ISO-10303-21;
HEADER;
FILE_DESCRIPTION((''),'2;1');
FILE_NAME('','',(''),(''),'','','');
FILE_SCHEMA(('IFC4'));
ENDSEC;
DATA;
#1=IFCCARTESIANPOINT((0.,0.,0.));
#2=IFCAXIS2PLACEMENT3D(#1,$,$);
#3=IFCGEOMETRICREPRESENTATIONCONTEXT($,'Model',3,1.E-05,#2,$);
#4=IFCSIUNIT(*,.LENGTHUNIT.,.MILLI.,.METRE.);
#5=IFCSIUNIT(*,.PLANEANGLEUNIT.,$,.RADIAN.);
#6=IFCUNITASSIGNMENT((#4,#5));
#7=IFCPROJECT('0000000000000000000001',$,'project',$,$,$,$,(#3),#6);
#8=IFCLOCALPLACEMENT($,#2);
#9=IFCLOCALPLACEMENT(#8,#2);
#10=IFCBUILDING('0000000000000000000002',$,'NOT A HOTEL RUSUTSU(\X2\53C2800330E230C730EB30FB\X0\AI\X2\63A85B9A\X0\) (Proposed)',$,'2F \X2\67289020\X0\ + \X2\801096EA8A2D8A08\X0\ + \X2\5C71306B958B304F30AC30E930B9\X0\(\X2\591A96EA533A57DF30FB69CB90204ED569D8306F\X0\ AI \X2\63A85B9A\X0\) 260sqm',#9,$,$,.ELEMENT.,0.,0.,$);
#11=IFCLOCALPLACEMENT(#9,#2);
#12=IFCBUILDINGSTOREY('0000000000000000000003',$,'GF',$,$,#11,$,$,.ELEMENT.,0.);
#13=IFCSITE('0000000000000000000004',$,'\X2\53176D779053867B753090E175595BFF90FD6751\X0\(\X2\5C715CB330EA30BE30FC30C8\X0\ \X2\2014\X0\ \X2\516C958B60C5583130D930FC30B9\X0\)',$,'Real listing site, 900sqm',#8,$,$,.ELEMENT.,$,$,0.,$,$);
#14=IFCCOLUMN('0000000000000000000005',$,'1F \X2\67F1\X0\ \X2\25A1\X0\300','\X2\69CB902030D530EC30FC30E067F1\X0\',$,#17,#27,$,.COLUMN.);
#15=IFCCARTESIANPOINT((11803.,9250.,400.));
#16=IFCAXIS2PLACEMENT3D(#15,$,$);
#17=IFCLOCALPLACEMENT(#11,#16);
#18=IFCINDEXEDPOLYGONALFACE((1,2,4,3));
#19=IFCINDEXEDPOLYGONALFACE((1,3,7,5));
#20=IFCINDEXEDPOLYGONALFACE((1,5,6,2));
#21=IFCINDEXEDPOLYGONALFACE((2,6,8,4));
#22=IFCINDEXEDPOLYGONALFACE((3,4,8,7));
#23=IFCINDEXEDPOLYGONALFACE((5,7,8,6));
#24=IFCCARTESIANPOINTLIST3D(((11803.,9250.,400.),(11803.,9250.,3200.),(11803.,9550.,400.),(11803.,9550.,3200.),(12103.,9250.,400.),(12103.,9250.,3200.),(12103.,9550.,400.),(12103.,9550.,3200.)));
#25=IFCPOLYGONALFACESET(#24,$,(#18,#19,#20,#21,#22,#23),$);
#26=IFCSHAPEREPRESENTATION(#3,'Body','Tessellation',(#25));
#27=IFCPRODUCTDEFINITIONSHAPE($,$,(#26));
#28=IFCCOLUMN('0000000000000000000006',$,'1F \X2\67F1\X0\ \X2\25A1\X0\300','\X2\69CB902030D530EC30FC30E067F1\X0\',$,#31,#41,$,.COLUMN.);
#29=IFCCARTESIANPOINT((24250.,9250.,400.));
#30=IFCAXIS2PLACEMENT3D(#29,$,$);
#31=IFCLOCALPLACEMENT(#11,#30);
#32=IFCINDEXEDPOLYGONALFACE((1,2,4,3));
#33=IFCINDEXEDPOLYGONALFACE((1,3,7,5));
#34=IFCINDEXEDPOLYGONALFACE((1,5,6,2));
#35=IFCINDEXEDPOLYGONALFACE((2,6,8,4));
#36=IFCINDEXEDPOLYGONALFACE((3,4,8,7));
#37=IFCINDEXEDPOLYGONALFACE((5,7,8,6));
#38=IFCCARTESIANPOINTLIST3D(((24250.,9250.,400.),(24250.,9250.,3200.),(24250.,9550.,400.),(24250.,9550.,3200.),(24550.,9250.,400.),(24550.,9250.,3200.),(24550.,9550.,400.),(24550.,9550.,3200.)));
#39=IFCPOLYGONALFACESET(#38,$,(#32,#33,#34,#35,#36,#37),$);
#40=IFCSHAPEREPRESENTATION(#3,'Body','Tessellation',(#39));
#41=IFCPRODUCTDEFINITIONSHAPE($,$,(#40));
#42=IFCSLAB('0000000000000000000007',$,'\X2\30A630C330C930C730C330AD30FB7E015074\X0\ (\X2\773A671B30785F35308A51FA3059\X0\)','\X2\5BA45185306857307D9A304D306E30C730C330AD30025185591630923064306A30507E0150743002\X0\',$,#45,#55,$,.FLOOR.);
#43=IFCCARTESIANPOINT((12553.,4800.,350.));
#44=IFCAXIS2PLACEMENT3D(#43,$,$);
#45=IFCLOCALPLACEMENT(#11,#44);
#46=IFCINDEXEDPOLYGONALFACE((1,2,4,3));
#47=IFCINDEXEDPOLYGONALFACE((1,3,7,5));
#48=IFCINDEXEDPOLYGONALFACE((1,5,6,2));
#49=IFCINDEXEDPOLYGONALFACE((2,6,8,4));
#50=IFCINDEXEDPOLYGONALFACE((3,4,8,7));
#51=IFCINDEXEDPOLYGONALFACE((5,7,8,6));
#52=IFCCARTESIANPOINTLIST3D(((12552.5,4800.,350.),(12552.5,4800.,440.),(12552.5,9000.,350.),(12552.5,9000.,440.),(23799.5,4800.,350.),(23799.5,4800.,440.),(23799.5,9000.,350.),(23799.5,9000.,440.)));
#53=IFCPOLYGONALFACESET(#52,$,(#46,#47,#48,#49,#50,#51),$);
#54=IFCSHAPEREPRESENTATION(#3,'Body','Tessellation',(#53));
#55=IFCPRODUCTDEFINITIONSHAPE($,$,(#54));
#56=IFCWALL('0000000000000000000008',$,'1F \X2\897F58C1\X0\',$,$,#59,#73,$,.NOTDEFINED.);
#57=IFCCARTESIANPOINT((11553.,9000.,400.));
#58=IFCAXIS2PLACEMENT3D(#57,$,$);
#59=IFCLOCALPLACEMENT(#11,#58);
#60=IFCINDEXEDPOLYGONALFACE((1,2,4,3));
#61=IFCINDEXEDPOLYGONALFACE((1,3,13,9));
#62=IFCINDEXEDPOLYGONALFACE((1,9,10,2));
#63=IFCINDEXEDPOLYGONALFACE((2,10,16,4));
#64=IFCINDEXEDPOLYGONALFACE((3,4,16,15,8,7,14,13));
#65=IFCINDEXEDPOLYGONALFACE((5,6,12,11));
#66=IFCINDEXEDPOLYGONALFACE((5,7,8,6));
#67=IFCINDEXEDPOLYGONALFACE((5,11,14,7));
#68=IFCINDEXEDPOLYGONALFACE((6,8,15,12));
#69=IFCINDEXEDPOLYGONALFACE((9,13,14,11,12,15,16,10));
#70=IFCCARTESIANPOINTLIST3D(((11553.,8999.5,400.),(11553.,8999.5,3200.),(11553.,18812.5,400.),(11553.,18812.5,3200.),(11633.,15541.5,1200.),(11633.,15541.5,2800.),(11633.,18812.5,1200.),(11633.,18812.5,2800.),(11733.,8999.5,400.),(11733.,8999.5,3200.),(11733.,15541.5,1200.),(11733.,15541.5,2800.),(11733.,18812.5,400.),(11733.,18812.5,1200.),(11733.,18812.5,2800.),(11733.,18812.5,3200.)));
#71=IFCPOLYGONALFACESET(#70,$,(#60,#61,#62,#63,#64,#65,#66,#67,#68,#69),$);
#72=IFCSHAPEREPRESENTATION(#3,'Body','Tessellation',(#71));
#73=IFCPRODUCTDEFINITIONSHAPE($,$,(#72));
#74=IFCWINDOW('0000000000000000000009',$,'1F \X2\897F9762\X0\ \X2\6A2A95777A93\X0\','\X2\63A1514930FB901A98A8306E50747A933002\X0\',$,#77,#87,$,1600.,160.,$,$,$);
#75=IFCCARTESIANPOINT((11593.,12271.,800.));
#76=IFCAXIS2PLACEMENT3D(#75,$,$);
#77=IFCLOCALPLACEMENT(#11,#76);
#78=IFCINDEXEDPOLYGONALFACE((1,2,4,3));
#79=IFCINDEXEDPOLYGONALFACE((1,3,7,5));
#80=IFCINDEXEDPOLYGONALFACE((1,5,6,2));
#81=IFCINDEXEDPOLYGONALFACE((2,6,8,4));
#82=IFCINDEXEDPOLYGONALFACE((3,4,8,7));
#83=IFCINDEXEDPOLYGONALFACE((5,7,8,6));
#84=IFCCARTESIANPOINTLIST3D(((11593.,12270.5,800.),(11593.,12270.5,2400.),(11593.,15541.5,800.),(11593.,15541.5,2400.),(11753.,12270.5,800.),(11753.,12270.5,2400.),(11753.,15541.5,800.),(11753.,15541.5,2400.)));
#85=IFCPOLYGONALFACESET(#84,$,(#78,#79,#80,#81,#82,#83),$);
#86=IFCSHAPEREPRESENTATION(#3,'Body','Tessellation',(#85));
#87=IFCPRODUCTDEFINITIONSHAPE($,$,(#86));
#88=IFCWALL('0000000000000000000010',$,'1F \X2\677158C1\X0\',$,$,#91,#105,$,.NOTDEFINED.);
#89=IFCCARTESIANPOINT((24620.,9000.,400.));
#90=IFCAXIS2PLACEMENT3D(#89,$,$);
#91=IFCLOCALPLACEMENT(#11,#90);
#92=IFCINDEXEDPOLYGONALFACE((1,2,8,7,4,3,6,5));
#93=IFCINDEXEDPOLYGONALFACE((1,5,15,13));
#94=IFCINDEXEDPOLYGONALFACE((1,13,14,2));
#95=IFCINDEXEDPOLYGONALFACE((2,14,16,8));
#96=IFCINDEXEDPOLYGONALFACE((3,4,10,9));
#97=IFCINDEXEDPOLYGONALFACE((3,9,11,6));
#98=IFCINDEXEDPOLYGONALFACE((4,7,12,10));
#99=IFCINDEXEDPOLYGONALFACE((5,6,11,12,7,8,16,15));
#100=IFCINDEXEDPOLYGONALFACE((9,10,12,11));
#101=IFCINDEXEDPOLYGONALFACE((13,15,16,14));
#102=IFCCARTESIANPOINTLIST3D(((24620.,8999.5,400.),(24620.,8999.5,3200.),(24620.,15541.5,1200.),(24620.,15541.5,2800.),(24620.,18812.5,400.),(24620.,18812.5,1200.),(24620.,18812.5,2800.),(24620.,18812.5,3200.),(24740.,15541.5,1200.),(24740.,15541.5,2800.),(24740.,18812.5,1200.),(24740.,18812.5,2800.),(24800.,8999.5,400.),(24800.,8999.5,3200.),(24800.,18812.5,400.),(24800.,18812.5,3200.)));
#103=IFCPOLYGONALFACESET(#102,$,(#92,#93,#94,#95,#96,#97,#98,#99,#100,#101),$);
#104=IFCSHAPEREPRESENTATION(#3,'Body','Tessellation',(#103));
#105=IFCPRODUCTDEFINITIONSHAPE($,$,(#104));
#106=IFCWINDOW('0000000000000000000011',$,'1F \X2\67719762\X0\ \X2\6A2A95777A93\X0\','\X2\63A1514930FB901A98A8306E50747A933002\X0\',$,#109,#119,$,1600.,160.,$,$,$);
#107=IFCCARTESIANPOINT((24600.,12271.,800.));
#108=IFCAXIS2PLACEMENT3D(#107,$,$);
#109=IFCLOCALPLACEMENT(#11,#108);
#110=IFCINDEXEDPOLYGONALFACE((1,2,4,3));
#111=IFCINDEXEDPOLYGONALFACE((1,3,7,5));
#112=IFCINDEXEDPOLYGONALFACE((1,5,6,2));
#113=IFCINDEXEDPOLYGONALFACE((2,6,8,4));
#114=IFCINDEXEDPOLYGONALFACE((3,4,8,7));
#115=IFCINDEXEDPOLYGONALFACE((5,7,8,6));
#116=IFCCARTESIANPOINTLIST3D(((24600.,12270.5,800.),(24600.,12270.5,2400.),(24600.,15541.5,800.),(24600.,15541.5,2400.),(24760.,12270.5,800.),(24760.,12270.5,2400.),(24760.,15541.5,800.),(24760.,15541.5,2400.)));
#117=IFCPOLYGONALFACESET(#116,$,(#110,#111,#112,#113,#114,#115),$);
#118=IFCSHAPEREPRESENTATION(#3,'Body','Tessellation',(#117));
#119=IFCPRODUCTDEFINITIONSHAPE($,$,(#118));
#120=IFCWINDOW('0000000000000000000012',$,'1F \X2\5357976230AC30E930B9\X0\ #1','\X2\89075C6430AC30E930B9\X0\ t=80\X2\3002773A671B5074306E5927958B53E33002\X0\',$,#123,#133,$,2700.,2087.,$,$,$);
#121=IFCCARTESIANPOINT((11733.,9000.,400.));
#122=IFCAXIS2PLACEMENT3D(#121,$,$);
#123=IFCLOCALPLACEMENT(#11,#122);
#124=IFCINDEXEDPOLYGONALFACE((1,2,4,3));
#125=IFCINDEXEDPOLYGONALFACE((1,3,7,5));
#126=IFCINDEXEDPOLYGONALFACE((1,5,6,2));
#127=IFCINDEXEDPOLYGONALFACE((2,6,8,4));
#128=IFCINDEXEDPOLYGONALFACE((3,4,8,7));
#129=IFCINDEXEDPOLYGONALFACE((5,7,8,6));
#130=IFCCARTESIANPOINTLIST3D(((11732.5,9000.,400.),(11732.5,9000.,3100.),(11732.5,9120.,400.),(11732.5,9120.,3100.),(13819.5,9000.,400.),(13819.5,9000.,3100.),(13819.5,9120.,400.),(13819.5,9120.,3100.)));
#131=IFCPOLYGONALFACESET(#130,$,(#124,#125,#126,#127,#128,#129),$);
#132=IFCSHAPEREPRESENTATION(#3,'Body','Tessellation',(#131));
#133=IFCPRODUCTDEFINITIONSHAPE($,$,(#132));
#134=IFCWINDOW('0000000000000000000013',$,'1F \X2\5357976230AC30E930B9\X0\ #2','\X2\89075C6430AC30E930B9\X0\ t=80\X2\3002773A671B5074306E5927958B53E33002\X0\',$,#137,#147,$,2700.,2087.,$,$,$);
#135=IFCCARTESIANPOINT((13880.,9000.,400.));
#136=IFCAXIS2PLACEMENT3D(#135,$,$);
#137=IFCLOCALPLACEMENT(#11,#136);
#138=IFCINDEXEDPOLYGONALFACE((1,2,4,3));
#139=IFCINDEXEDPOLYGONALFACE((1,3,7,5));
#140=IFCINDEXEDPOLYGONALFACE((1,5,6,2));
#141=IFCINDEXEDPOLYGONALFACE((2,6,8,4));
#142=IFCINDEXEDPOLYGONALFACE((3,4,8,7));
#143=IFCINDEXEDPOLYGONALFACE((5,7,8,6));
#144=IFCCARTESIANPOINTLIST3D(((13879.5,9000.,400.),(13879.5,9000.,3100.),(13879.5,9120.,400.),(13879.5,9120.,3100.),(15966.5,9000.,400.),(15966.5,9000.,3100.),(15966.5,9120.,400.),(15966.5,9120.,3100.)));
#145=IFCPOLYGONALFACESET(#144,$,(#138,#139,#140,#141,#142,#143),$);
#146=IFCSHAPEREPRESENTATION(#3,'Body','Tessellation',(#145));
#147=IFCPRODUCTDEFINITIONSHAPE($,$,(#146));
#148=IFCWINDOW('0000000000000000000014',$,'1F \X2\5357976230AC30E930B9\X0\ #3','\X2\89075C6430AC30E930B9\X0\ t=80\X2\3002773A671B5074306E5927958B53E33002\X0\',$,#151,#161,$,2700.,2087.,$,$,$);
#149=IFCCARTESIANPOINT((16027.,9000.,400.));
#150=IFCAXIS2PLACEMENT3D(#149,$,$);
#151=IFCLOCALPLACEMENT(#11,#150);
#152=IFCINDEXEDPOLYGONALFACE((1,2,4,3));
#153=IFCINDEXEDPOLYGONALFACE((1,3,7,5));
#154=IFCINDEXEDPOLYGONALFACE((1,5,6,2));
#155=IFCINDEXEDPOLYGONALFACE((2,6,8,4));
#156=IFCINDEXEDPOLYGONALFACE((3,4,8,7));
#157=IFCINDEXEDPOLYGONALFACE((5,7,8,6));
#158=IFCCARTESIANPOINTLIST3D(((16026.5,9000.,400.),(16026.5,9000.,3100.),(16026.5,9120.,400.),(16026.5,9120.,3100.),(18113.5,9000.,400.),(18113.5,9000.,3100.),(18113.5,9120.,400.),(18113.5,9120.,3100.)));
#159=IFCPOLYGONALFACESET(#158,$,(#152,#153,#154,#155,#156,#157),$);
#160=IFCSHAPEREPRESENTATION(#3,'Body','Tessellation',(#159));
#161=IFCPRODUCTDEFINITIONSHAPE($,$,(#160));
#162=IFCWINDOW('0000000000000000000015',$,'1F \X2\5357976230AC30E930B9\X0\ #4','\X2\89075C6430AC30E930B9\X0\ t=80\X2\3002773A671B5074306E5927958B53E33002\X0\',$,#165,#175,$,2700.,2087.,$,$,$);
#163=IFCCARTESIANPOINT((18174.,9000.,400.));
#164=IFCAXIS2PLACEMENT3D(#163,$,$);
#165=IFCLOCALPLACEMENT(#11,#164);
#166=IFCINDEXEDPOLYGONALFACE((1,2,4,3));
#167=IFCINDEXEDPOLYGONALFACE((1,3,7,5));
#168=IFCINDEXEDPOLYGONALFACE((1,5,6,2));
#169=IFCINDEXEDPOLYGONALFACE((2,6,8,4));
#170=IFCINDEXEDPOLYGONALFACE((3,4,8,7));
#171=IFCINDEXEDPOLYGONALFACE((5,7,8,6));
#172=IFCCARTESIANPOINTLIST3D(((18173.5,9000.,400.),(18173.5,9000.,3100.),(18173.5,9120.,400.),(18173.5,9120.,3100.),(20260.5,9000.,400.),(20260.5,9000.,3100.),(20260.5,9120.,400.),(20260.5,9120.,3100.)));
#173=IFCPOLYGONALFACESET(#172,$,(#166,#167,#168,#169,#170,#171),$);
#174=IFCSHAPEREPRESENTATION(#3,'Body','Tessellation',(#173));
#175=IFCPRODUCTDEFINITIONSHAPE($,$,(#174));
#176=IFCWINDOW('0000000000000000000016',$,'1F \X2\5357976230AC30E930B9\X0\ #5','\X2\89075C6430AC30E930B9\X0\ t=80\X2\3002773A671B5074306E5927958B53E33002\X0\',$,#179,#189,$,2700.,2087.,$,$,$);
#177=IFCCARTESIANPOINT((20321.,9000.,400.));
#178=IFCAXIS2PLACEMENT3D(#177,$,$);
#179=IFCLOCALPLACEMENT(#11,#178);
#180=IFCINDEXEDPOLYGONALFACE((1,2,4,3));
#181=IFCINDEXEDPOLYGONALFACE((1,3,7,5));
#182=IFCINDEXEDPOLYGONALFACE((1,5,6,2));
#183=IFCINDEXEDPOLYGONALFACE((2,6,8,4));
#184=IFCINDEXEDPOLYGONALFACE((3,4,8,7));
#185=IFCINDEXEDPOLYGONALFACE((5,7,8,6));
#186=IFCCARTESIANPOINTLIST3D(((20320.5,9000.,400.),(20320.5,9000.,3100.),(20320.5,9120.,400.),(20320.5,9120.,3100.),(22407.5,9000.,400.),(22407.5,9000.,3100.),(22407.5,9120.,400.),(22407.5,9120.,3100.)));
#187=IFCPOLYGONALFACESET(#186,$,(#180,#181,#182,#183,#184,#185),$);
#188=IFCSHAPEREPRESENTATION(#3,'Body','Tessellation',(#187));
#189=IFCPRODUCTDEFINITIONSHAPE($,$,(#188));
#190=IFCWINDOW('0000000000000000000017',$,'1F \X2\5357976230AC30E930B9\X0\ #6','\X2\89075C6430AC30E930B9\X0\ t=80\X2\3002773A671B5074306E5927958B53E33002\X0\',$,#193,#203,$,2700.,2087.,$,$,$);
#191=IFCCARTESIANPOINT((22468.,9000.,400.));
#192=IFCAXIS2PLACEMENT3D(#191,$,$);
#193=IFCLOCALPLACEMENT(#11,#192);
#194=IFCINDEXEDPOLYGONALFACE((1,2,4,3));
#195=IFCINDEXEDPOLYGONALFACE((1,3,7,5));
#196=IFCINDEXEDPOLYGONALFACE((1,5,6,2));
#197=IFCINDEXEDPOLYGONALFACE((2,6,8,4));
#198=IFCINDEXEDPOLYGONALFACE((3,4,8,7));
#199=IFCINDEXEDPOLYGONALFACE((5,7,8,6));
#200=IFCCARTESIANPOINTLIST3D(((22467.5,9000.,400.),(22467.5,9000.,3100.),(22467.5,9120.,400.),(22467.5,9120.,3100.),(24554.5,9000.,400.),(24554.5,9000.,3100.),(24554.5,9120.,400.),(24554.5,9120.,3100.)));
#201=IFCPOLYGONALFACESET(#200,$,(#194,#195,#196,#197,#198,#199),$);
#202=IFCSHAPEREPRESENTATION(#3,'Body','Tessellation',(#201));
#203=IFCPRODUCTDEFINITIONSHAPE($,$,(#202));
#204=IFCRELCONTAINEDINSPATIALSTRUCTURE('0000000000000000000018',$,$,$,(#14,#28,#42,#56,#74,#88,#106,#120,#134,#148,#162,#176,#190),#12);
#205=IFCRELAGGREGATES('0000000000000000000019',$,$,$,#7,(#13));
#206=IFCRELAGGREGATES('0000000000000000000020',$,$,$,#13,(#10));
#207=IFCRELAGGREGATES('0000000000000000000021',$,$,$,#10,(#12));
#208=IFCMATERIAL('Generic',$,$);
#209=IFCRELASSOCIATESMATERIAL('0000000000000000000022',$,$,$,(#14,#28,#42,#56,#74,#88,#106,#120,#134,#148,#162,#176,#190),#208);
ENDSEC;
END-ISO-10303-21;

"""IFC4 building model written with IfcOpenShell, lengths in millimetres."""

from ifc_helpers import new_model, si_unit, frame, frame_2d, origin, place, context, project, spatial, rectangle, extrude, material, element, fill, save


model = new_model("IFC4")

# Units and contexts
model_context = context("Model", 3, precision=1e-05, world=origin())
ifc_project = project(units=[si_unit("LENGTHUNIT", "METRE", prefix="MILLI"), si_unit("PLANEANGLEUNIT", "RADIAN")], contexts=[model_context])

# Site, building, storey
site_placement = place(None, origin())
site = spatial("IfcSite", under=ifc_project, at=site_placement, Name="北海道虻田郡留寿都村(山岳リゾート — 公開情報ベース)", ObjectType="Real listing site, 900sqm", CompositionType="ELEMENT", RefElevation=0.0)
building_placement = place(site_placement, origin())
building = spatial("IfcBuilding", under=site, at=building_placement, Name="NOT A HOTEL RUSUTSU(参考モデル・AI推定) (Proposed)", ObjectType="2F 木造 + 耐雪設計 + 山に開くガラス(多雪区域・構造仕様は AI 推定) 260sqm", CompositionType="ELEMENT", ElevationOfRefHeight=0.0, ElevationOfTerrain=0.0)
storey_placement = place(building_placement, origin())
storey = spatial("IfcBuildingStorey", under=building, at=storey_placement, Name="GF", CompositionType="ELEMENT", Elevation=0.0)

# Columns
ifc_material_1 = material(Name="Generic")
column_1_placement = place(storey_placement, frame((11803.0, 9250.0, 400.0)))
element("IfcColumn", 1, at=column_1_placement, inside=storey, material=ifc_material_1, Name="1F 柱 □300", Description="構造フレーム柱", PredefinedType="COLUMN", context=model_context, shape_type="SweptSolid", body=[
    extrude(rectangle(XDim=300.0, YDim=300.0, at=frame_2d((150.0, 150.0))), frame((11803.0, 9250.0, 400.0)), (0.0, 0.0, 1.0), 2800.0),
])
column_2_placement = place(storey_placement, frame((24250.0, 9250.0, 400.0)))
element("IfcColumn", 2, at=column_2_placement, inside=storey, material=ifc_material_1, Name="1F 柱 □300", Description="構造フレーム柱", PredefinedType="COLUMN", context=model_context, shape_type="SweptSolid", body=[
    extrude(rectangle(XDim=300.0, YDim=300.0, at=frame_2d((150.0, 150.0))), frame((24250.0, 9250.0, 400.0)), (0.0, 0.0, 1.0), 2800.0),
])

# Slab
slab_1_placement = place(storey_placement, frame((12553.0, 4800.0, 350.0)))
element("IfcSlab", 3, at=slab_1_placement, inside=storey, material=ifc_material_1, Name="ウッドデッキ・縁側 (眺望へ張り出す)", Description="室内と地続きのデッキ。内外をつなぐ縁側。", PredefinedType="FLOOR", context=model_context, shape_type="SweptSolid", body=[
    extrude(rectangle(XDim=11247.0, YDim=4200.0, at=frame_2d((5623.0, 2100.0))), frame((12553.0, 4800.0, 350.0)), (0.0, 0.0, 1.0), 90.0),
])

# Walls, openings, windows
wall_1_placement = place(storey_placement, frame((11553.0, 9000.0, 400.0)))
wall_1 = element("IfcWall", 4, at=wall_1_placement, inside=storey, material=ifc_material_1, Name="1F 西壁", PredefinedType="NOTDEFINED", context=model_context, shape_type="SweptSolid", body=[
    extrude(rectangle(XDim=180.0, YDim=9813.0, at=frame_2d((90.0, 4906.0))), frame((11553.0, 9000.0, 400.0)), (0.0, 0.0, 1.0), 2800.0),
])
opening_1_placement = place(storey_placement, frame((11593.0, 12271.0, 800.0)))
opening_1 = element("IfcOpeningElement", 5, at=opening_1_placement, cuts=wall_1, PredefinedType="NOTDEFINED", context=model_context, shape_type="SweptSolid", body=[
    extrude(rectangle(XDim=160.0, YDim=3271.0, at=frame_2d((80.0, 1635.0))), frame((11593.0, 12271.0, 800.0)), (0.0, 0.0, 1.0), 1600.0),
])
window_1_placement = place(storey_placement, frame((11593.0, 12271.0, 800.0)))
window_1 = element("IfcWindow", 6, at=window_1_placement, inside=storey, material=ifc_material_1, Name="1F 西面 横長窓", Description="採光・通風の側窓。", OverallHeight=1600.0, OverallWidth=160.0, context=model_context, shape_type="SweptSolid", body=[
    extrude(rectangle(XDim=160.0, YDim=3271.0, at=frame_2d((80.0, 1635.0))), frame((11593.0, 12271.0, 800.0)), (0.0, 0.0, 1.0), 1600.0),
])
fill(opening_1, window_1)
wall_2_placement = place(storey_placement, frame((24620.0, 9000.0, 400.0)))
wall_2 = element("IfcWall", 7, at=wall_2_placement, inside=storey, material=ifc_material_1, Name="1F 東壁", PredefinedType="NOTDEFINED", context=model_context, shape_type="SweptSolid", body=[
    extrude(rectangle(XDim=180.0, YDim=9813.0, at=frame_2d((90.0, 4906.0))), frame((24620.0, 9000.0, 400.0)), (0.0, 0.0, 1.0), 2800.0),
])
opening_2_placement = place(storey_placement, frame((24600.0, 12271.0, 800.0)))
opening_2 = element("IfcOpeningElement", 8, at=opening_2_placement, cuts=wall_2, PredefinedType="NOTDEFINED", context=model_context, shape_type="SweptSolid", body=[
    extrude(rectangle(XDim=160.0, YDim=3271.0, at=frame_2d((80.0, 1635.0))), frame((24600.0, 12271.0, 800.0)), (0.0, 0.0, 1.0), 1600.0),
])
window_2_placement = place(storey_placement, frame((24600.0, 12271.0, 800.0)))
window_2 = element("IfcWindow", 9, at=window_2_placement, inside=storey, material=ifc_material_1, Name="1F 東面 横長窓", Description="採光・通風の側窓。", OverallHeight=1600.0, OverallWidth=160.0, context=model_context, shape_type="SweptSolid", body=[
    extrude(rectangle(XDim=160.0, YDim=3271.0, at=frame_2d((80.0, 1635.0))), frame((24600.0, 12271.0, 800.0)), (0.0, 0.0, 1.0), 1600.0),
])
fill(opening_2, window_2)

# Windows
window_3_placement = place(storey_placement, frame((11733.0, 9000.0, 400.0)))
element("IfcWindow", 10, at=window_3_placement, inside=storey, material=ifc_material_1, Name="1F 南面ガラス #1", Description="複層ガラス t=80。眺望側の大開口。", OverallHeight=2700.0, OverallWidth=2087.0, context=model_context, shape_type="SweptSolid", body=[
    extrude(rectangle(XDim=2087.0, YDim=120.0, at=frame_2d((1043.0, 60.0))), frame((11733.0, 9000.0, 400.0)), (0.0, 0.0, 1.0), 2700.0),
])
window_4_placement = place(storey_placement, frame((13880.0, 9000.0, 400.0)))
element("IfcWindow", 11, at=window_4_placement, inside=storey, material=ifc_material_1, Name="1F 南面ガラス #2", Description="複層ガラス t=80。眺望側の大開口。", OverallHeight=2700.0, OverallWidth=2087.0, context=model_context, shape_type="SweptSolid", body=[
    extrude(rectangle(XDim=2087.0, YDim=120.0, at=frame_2d((1043.0, 60.0))), frame((13880.0, 9000.0, 400.0)), (0.0, 0.0, 1.0), 2700.0),
])
window_5_placement = place(storey_placement, frame((16027.0, 9000.0, 400.0)))
element("IfcWindow", 12, at=window_5_placement, inside=storey, material=ifc_material_1, Name="1F 南面ガラス #3", Description="複層ガラス t=80。眺望側の大開口。", OverallHeight=2700.0, OverallWidth=2087.0, context=model_context, shape_type="SweptSolid", body=[
    extrude(rectangle(XDim=2087.0, YDim=120.0, at=frame_2d((1043.0, 60.0))), frame((16027.0, 9000.0, 400.0)), (0.0, 0.0, 1.0), 2700.0),
])
window_6_placement = place(storey_placement, frame((18174.0, 9000.0, 400.0)))
element("IfcWindow", 13, at=window_6_placement, inside=storey, material=ifc_material_1, Name="1F 南面ガラス #4", Description="複層ガラス t=80。眺望側の大開口。", OverallHeight=2700.0, OverallWidth=2087.0, context=model_context, shape_type="SweptSolid", body=[
    extrude(rectangle(XDim=2087.0, YDim=120.0, at=frame_2d((1043.0, 60.0))), frame((18174.0, 9000.0, 400.0)), (0.0, 0.0, 1.0), 2700.0),
])
window_7_placement = place(storey_placement, frame((20321.0, 9000.0, 400.0)))
element("IfcWindow", 14, at=window_7_placement, inside=storey, material=ifc_material_1, Name="1F 南面ガラス #5", Description="複層ガラス t=80。眺望側の大開口。", OverallHeight=2700.0, OverallWidth=2087.0, context=model_context, shape_type="SweptSolid", body=[
    extrude(rectangle(XDim=2087.0, YDim=120.0, at=frame_2d((1043.0, 60.0))), frame((20321.0, 9000.0, 400.0)), (0.0, 0.0, 1.0), 2700.0),
])
window_8_placement = place(storey_placement, frame((22468.0, 9000.0, 400.0)))
element("IfcWindow", 15, at=window_8_placement, inside=storey, material=ifc_material_1, Name="1F 南面ガラス #6", Description="複層ガラス t=80。眺望側の大開口。", OverallHeight=2700.0, OverallWidth=2087.0, context=model_context, shape_type="SweptSolid", body=[
    extrude(rectangle(XDim=2087.0, YDim=120.0, at=frame_2d((1043.0, 60.0))), frame((22468.0, 9000.0, 400.0)), (0.0, 0.0, 1.0), 2700.0),
])

save(model, "model.ifc")
